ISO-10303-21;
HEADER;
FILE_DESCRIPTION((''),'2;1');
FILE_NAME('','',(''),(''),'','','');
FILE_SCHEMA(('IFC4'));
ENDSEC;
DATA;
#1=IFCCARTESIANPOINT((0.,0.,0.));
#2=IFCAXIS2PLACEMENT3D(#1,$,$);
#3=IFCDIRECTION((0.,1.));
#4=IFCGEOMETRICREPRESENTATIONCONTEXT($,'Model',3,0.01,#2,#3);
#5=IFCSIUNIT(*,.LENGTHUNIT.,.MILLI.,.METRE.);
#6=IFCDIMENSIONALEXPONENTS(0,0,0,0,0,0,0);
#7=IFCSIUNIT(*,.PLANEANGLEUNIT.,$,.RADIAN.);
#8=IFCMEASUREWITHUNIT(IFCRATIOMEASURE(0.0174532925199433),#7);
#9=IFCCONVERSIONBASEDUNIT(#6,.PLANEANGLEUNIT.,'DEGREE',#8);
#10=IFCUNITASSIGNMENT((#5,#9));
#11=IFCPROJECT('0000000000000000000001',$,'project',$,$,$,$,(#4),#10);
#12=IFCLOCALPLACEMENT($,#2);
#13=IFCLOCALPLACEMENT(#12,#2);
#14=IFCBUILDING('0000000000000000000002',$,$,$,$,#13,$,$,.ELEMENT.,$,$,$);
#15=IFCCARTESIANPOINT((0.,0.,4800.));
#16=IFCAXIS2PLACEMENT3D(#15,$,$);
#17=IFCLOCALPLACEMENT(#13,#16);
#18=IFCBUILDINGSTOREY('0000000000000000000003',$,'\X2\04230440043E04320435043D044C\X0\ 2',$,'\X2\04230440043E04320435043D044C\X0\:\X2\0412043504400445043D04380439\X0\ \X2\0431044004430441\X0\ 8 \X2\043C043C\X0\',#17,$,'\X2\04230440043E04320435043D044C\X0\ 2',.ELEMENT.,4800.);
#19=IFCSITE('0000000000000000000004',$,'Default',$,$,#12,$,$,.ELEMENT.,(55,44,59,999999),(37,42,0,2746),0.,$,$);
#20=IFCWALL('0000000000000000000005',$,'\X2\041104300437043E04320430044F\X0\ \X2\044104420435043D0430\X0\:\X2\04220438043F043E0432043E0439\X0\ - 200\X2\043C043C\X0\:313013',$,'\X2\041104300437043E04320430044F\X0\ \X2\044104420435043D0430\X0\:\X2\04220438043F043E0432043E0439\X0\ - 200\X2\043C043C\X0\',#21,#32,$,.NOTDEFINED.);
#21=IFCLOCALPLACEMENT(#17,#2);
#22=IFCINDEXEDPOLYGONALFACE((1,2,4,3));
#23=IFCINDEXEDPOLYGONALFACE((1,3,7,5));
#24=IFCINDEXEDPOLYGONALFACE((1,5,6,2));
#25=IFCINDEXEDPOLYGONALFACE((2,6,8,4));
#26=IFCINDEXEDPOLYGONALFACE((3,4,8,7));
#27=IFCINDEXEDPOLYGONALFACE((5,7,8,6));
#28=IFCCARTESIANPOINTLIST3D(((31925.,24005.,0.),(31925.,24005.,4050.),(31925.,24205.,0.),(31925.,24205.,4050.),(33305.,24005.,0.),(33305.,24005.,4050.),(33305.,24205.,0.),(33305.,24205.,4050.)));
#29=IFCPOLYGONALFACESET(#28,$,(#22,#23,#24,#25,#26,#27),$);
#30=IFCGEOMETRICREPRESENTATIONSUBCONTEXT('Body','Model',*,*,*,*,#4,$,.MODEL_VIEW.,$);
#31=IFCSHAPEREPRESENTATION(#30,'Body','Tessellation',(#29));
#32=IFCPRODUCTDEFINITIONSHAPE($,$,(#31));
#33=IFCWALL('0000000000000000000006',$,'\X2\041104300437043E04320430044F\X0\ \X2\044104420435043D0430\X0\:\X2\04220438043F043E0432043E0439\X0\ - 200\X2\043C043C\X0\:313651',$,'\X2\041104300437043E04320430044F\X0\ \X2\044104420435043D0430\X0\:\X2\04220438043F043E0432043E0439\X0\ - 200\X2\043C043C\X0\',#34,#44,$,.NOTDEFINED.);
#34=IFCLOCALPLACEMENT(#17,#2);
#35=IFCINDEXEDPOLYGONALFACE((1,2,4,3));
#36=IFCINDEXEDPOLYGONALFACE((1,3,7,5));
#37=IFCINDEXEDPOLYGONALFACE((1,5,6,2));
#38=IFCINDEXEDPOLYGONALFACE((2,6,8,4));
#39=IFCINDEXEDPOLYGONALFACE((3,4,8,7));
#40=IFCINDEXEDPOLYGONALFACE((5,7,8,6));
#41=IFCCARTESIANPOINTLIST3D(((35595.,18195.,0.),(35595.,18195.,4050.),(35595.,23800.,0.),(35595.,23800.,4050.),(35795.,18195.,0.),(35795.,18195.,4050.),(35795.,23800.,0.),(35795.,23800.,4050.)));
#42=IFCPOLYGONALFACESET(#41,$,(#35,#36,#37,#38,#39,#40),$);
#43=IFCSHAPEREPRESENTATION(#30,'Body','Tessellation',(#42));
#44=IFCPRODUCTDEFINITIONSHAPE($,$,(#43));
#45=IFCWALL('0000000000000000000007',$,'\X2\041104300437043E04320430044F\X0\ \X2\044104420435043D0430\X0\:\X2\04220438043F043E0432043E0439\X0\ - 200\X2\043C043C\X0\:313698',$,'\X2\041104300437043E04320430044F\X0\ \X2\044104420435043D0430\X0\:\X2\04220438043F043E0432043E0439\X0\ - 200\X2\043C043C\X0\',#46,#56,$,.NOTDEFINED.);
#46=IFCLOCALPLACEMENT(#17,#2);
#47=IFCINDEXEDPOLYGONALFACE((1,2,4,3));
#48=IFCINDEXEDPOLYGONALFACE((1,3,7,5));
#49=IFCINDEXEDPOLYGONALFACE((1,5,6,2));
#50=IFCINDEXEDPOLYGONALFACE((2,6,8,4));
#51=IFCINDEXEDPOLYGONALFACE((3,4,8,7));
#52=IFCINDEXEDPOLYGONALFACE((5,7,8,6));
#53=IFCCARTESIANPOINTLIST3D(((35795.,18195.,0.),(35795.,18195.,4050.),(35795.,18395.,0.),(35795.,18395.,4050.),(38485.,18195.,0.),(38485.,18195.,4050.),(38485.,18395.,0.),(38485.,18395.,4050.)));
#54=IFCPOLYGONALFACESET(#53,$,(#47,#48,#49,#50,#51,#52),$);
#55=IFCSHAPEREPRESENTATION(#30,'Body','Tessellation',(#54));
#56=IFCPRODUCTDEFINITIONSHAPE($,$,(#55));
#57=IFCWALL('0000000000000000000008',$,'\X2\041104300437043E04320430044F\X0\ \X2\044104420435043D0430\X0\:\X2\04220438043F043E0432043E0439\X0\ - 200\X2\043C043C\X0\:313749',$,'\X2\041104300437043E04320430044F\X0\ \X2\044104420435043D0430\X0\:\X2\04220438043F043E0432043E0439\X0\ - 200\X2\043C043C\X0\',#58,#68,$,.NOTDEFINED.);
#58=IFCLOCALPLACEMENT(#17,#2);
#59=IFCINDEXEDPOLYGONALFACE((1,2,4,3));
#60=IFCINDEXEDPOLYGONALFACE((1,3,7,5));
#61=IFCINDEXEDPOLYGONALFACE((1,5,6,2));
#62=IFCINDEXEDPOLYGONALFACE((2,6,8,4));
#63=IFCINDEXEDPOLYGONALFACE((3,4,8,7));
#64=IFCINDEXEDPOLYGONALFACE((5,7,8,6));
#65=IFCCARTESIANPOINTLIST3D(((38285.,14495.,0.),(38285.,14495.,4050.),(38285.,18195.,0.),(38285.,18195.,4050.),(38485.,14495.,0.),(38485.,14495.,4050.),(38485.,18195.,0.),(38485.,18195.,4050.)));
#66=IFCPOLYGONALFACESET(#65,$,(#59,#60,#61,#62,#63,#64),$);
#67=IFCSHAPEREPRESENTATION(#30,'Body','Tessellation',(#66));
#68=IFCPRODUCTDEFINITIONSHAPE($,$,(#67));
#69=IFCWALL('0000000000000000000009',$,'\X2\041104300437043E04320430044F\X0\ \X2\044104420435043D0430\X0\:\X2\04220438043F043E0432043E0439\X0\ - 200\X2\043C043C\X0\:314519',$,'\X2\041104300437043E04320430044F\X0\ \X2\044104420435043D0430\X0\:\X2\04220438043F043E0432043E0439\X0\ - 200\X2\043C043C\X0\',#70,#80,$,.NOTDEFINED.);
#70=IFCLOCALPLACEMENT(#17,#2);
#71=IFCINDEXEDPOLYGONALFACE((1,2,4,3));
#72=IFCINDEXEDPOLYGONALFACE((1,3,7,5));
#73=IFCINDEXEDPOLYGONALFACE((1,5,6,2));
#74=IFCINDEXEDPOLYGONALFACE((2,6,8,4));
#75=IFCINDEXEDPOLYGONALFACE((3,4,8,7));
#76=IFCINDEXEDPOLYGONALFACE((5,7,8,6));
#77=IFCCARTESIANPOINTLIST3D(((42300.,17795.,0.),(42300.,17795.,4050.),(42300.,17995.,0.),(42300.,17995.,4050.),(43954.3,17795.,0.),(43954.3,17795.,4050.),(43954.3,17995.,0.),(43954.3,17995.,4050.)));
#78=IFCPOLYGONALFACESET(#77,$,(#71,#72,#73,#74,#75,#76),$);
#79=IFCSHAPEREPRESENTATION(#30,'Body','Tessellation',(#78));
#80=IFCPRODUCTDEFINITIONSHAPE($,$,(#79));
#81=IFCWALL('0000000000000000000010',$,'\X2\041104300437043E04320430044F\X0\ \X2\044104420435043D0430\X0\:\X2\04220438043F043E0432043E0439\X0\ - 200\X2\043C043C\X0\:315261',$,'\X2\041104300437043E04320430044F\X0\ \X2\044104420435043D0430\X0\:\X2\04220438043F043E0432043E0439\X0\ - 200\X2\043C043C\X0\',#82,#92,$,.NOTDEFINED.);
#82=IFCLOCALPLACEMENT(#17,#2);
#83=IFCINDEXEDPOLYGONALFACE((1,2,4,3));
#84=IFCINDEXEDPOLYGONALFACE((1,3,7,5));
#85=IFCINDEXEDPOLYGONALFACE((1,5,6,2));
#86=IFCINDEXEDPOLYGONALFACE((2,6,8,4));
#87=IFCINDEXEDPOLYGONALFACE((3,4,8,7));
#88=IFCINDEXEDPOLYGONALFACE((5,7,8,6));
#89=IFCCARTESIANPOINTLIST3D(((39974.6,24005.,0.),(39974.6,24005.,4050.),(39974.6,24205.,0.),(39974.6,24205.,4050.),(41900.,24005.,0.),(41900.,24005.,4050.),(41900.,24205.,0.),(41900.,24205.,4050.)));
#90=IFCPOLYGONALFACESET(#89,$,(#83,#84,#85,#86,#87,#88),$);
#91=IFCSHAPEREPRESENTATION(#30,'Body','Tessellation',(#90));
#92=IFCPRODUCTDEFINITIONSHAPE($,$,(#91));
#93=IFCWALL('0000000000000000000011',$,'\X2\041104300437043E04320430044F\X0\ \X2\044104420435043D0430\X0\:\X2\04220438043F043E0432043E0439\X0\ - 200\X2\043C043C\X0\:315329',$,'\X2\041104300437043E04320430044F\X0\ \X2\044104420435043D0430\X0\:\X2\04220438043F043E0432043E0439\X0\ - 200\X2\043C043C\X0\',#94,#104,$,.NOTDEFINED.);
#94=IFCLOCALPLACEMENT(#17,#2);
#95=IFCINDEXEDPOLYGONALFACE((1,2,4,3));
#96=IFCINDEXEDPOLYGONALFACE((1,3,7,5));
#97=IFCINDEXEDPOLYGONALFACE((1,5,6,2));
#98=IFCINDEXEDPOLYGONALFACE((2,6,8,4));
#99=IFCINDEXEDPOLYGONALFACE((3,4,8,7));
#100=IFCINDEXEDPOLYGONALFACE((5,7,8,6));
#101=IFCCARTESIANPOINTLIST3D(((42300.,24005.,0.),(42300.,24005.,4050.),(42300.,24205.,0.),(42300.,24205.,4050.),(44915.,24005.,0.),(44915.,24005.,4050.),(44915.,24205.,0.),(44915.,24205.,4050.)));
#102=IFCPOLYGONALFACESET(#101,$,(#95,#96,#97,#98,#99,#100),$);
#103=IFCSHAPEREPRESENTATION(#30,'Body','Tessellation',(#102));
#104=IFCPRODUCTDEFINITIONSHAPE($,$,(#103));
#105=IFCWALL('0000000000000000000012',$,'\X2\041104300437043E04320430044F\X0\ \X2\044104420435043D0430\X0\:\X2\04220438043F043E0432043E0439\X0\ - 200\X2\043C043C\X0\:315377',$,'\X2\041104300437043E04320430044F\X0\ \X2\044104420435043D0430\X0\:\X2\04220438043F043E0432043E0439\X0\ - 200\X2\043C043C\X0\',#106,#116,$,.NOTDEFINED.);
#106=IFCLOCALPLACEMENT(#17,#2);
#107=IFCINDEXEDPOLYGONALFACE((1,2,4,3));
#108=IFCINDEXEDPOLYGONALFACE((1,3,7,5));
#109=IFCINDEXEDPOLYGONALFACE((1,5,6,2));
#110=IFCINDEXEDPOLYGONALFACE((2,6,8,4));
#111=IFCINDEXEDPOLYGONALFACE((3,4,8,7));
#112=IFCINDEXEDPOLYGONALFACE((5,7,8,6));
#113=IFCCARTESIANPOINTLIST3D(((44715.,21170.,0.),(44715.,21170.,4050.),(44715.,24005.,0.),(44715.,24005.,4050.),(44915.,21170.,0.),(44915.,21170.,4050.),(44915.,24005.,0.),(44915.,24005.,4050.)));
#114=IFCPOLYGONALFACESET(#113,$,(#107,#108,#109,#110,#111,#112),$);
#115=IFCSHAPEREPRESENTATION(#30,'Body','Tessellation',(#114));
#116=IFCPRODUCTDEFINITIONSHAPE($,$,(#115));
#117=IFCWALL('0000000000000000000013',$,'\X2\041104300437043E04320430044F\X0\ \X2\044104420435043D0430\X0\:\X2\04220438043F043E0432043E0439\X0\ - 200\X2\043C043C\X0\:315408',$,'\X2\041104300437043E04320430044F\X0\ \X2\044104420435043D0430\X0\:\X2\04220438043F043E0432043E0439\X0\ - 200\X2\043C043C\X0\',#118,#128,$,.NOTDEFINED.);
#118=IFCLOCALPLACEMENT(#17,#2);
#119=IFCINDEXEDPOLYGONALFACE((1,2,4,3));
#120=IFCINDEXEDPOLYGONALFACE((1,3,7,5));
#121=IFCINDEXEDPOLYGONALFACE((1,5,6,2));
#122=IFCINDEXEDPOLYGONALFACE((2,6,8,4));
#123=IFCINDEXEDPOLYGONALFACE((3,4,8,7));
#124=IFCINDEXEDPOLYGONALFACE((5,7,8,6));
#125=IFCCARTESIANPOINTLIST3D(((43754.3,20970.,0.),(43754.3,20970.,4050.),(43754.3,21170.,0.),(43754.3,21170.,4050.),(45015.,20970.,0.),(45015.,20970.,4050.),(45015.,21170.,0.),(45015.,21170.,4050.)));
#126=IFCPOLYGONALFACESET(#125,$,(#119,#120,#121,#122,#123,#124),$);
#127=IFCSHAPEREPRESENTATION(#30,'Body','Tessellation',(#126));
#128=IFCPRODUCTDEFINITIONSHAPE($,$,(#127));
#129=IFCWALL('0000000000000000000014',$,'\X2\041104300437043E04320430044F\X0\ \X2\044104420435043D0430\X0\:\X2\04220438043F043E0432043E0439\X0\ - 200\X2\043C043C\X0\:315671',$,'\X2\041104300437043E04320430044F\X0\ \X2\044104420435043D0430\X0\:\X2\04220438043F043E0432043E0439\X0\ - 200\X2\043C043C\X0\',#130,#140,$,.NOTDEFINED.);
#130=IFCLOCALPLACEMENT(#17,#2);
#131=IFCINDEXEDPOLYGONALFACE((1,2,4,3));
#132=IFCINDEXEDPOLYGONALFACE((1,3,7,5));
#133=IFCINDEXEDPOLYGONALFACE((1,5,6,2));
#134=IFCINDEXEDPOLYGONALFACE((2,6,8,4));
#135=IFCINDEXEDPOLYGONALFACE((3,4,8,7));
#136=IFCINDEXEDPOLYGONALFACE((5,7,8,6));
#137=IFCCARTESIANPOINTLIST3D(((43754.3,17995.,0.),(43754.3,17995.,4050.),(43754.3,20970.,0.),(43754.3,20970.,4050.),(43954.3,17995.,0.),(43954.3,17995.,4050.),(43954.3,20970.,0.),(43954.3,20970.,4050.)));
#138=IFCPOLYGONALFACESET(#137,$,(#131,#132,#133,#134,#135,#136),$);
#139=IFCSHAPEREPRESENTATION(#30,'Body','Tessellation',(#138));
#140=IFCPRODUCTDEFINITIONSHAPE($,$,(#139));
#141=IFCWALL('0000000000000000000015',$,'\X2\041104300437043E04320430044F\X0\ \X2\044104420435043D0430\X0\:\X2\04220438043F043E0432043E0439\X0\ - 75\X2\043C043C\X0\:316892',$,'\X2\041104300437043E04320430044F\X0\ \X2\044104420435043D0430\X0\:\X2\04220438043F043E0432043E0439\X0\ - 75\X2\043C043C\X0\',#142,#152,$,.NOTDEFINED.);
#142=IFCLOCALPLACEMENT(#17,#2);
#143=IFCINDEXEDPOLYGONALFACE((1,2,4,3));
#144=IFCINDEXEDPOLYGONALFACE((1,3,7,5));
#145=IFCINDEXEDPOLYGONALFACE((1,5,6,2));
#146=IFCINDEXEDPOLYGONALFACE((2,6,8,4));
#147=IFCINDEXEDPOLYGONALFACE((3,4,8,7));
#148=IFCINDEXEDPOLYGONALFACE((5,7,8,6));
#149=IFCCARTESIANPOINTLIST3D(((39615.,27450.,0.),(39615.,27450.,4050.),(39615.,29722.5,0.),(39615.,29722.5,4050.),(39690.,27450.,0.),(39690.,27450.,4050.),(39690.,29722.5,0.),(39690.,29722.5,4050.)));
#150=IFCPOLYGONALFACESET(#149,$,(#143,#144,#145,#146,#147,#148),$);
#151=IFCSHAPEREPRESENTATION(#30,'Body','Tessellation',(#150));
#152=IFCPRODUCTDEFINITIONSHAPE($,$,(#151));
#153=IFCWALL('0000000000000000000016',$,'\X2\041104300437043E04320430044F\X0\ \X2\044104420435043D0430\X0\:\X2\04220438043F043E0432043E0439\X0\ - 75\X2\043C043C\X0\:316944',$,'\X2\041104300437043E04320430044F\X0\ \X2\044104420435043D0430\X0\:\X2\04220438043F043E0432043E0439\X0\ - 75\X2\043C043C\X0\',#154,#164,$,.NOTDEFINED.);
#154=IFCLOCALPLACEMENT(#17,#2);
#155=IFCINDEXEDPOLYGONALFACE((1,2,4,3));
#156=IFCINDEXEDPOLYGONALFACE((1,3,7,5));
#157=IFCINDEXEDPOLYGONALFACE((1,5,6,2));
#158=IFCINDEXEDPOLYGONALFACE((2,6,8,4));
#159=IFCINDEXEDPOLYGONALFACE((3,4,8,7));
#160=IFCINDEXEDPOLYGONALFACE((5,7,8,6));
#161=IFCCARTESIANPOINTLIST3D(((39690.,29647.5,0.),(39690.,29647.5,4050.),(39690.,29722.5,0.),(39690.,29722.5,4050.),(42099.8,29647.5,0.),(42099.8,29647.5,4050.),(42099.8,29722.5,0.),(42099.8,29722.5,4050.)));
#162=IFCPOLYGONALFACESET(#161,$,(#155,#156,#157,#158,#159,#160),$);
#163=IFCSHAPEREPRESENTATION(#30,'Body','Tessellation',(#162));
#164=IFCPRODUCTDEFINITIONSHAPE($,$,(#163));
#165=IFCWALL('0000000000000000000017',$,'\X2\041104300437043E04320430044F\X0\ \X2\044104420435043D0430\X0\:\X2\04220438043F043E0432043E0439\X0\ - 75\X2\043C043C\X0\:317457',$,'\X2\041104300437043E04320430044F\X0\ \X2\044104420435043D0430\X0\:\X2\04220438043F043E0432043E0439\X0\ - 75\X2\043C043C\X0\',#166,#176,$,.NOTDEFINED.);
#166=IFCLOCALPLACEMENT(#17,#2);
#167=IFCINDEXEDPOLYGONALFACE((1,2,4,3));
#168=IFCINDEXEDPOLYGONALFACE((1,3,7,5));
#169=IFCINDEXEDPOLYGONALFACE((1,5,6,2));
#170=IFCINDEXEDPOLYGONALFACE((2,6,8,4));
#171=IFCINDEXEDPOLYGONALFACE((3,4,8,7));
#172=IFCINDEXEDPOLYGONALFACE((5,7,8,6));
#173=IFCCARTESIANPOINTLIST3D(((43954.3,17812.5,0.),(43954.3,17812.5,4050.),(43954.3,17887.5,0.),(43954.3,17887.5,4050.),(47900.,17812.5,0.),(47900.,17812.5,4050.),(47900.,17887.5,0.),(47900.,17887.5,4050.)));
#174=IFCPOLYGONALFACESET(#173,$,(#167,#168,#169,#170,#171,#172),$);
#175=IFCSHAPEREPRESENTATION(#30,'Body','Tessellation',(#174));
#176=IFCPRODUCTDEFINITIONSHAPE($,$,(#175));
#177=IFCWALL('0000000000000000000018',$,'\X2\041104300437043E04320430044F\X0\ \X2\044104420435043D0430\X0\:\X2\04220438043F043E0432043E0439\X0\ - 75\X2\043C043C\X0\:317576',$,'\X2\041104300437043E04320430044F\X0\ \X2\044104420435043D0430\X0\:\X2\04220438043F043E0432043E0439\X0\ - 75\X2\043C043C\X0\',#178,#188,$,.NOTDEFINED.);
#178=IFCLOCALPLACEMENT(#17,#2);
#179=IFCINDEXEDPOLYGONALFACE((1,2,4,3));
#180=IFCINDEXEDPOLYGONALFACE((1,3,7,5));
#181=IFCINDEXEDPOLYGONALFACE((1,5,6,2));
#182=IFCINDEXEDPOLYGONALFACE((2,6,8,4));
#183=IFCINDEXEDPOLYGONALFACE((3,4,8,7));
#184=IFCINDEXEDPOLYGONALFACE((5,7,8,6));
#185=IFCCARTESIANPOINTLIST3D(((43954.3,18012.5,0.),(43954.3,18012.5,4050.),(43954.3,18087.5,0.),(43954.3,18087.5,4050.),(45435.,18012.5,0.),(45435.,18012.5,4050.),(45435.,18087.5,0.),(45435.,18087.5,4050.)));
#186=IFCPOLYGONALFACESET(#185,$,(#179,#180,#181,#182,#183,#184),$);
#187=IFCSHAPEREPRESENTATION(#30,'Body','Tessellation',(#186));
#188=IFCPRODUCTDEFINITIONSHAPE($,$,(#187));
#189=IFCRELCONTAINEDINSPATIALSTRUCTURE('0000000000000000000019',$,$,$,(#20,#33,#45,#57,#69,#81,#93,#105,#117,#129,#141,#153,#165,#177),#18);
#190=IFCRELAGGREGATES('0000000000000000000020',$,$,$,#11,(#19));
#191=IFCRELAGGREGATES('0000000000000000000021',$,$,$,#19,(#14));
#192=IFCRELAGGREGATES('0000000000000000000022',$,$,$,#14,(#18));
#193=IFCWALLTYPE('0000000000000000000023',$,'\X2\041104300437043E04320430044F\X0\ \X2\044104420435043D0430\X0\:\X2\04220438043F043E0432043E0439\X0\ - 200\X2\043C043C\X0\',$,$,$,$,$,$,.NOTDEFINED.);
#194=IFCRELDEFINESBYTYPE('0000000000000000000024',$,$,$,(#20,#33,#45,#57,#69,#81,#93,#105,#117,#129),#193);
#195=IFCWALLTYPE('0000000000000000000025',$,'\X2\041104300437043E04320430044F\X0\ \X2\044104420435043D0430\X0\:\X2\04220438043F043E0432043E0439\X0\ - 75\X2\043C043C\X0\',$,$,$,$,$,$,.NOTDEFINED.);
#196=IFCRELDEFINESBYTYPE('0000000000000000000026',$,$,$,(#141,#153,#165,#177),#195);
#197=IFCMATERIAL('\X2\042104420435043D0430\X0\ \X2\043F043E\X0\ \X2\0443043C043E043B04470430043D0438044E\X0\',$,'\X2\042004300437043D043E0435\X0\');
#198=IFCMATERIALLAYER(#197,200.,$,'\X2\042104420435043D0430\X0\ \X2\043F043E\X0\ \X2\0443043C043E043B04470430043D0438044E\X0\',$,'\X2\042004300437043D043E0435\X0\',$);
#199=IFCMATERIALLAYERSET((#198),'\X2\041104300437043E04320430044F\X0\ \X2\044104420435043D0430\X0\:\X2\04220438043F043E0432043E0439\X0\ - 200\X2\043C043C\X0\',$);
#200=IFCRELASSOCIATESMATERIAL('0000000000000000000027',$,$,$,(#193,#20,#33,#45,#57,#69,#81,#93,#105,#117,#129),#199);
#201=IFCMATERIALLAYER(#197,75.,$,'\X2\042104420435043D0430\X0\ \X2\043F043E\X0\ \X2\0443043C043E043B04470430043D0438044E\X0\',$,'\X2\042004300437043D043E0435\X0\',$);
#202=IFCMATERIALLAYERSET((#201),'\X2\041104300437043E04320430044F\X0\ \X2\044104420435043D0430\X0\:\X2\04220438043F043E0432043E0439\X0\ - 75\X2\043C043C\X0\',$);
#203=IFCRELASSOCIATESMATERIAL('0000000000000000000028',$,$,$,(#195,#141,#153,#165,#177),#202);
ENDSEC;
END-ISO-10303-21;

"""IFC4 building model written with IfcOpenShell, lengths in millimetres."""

from ifc_helpers import new_model, entity, si_unit, converted_unit, direction, frame, frame_2d, origin, place, context, subcontext, project, spatial, rectangle, extrude, material, layer, layer_set, layer_usage, type_object, element, save


model = new_model("IFC4")

# Units and contexts
model_context = context("Model", 3, precision=0.01, world=origin(), true_north=direction((0.0, 1.0)))
body_context = subcontext(model_context, "Body", "Model", "MODEL_VIEW")
ifc_project = project(units=[si_unit("LENGTHUNIT", "METRE", prefix="MILLI"), converted_unit("PLANEANGLEUNIT", "DEGREE", entity("IfcRatioMeasure", 0.0174532925199433), si_unit("PLANEANGLEUNIT", "RADIAN"), dimensions=[0, 0, 0, 0, 0, 0, 0])], contexts=[model_context])

# Site, building, storey
site_placement = place(None, origin())
site = spatial("IfcSite", under=ifc_project, at=site_placement, Name="Default", CompositionType="ELEMENT", RefLatitude=(55, 44, 59, 999999), RefLongitude=(37, 42, 0, 2746), RefElevation=0.0)
building_placement = place(site_placement, origin())
building = spatial("IfcBuilding", under=site, at=building_placement, CompositionType="ELEMENT")
storey_placement = place(building_placement, frame((0.0, 0.0, 4800.0)))
storey = spatial("IfcBuildingStorey", under=building, at=storey_placement, Name="Уровень 2", ObjectType="Уровень:Верхний брус 8 мм", LongName="Уровень 2", CompositionType="ELEMENT", Elevation=4800.0)

# Walls
ifc_material_1 = material(Name="Стена по умолчанию", Category="Разное")
ifc_layer_1 = layer(ifc_material_1, 200.0, Name="Стена по умолчанию", Category="Разное")
ifc_layer_set_1 = layer_set([ifc_layer_1], Name="Базовая стена:Типовой - 200мм")
ifc_layer_usage_1 = layer_usage(ifc_layer_set_1, "AXIS2", "NEGATIVE", 100.0)
wall_type_1 = type_object("IfcWallType", Name="Базовая стена:Типовой - 200мм", PredefinedType="NOTDEFINED", material=ifc_layer_set_1)
wall_1_placement = place(storey_placement, frame((33305.0, 24105.0, 0.0), z_axis=(0.0, 0.0, 1.0), x_axis=(-1.0, 0.0, 0.0)))
element("IfcWall", 1, at=wall_1_placement, inside=storey, type_object=wall_type_1, material=ifc_layer_usage_1, Name="Базовая стена:Типовой - 200мм:313013", ObjectType="Базовая стена:Типовой - 200мм", PredefinedType="NOTDEFINED", context=body_context, shape_type="SweptSolid", body=[
    extrude(rectangle(XDim=1380.0, YDim=200.0, at=frame_2d((690.0, 0.0), x_axis=(-1.0, 0.0))), origin(), (0.0, 0.0, 1.0), 4050.0),
])
ifc_layer_usage_2 = layer_usage(ifc_layer_set_1, "AXIS2", "NEGATIVE", 100.0)
wall_2_placement = place(storey_placement, frame((35695.0, 23800.0, 0.0), z_axis=(0.0, 0.0, 1.0), x_axis=(0.0, -1.0, 0.0)))
element("IfcWall", 2, at=wall_2_placement, inside=storey, type_object=wall_type_1, material=ifc_layer_usage_2, Name="Базовая стена:Типовой - 200мм:313651", ObjectType="Базовая стена:Типовой - 200мм", PredefinedType="NOTDEFINED", context=body_context, shape_type="SweptSolid", body=[
    extrude(rectangle(XDim=5605.0, YDim=200.0, at=frame_2d((2802.5, 0.0), x_axis=(-1.0, 0.0))), origin(), (0.0, 0.0, 1.0), 4050.0),
])
ifc_layer_usage_3 = layer_usage(ifc_layer_set_1, "AXIS2", "NEGATIVE", 100.0)
wall_3_placement = place(storey_placement, frame((35795.0, 18295.0, 0.0)))
element("IfcWall", 3, at=wall_3_placement, inside=storey, type_object=wall_type_1, material=ifc_layer_usage_3, Name="Базовая стена:Типовой - 200мм:313698", ObjectType="Базовая стена:Типовой - 200мм", PredefinedType="NOTDEFINED", context=body_context, shape_type="SweptSolid", body=[
    extrude(rectangle(XDim=2690.0, YDim=200.0, at=frame_2d((1345.0, 0.0), x_axis=(-1.0, 0.0))), origin(), (0.0, 0.0, 1.0), 4050.0),
])
ifc_layer_usage_4 = layer_usage(ifc_layer_set_1, "AXIS2", "NEGATIVE", 100.0)
wall_4_placement = place(storey_placement, frame((38385.0, 18195.0, 0.0), z_axis=(0.0, 0.0, 1.0), x_axis=(0.0, -1.0, 0.0)))
element("IfcWall", 4, at=wall_4_placement, inside=storey, type_object=wall_type_1, material=ifc_layer_usage_4, Name="Базовая стена:Типовой - 200мм:313749", ObjectType="Базовая стена:Типовой - 200мм", PredefinedType="NOTDEFINED", context=body_context, shape_type="SweptSolid", body=[
    extrude(rectangle(XDim=3700.0, YDim=200.0, at=frame_2d((1850.0, 0.0), x_axis=(-1.0, 0.0))), origin(), (0.0, 0.0, 1.0), 4050.0),
])
ifc_layer_usage_5 = layer_usage(ifc_layer_set_1, "AXIS2", "NEGATIVE", 100.0)
wall_5_placement = place(storey_placement, frame((42300.0, 17895.0, 0.0)))
element("IfcWall", 5, at=wall_5_placement, inside=storey, type_object=wall_type_1, material=ifc_layer_usage_5, Name="Базовая стена:Типовой - 200мм:314519", ObjectType="Базовая стена:Типовой - 200мм", PredefinedType="NOTDEFINED", context=body_context, shape_type="SweptSolid", body=[
    extrude(rectangle(XDim=1654.3, YDim=200.0, at=frame_2d((827.2, 0.0), x_axis=(-1.0, 0.0))), origin(), (0.0, 0.0, 1.0), 4050.0),
])

# Walls
ifc_layer_usage_6 = layer_usage(ifc_layer_set_1, "AXIS2", "NEGATIVE", 100.0)
wall_6_placement = place(storey_placement, frame((39974.6, 24105.0, 0.0)))
element("IfcWall", 6, at=wall_6_placement, inside=storey, type_object=wall_type_1, material=ifc_layer_usage_6, Name="Базовая стена:Типовой - 200мм:315261", ObjectType="Базовая стена:Типовой - 200мм", PredefinedType="NOTDEFINED", context=body_context, shape_type="SweptSolid", body=[
    extrude(rectangle(XDim=1925.4, YDim=200.0, at=frame_2d((962.7, 0.0), x_axis=(-1.0, 0.0))), origin(), (0.0, 0.0, 1.0), 4050.0),
])
ifc_layer_usage_7 = layer_usage(ifc_layer_set_1, "AXIS2", "NEGATIVE", 100.0)
wall_7_placement = place(storey_placement, frame((42300.0, 24105.0, 0.0)))
element("IfcWall", 7, at=wall_7_placement, inside=storey, type_object=wall_type_1, material=ifc_layer_usage_7, Name="Базовая стена:Типовой - 200мм:315329", ObjectType="Базовая стена:Типовой - 200мм", PredefinedType="NOTDEFINED", context=body_context, shape_type="SweptSolid", body=[
    extrude(rectangle(XDim=2615.0, YDim=200.0, at=frame_2d((1307.5, 0.0), x_axis=(-1.0, 0.0))), origin(), (0.0, 0.0, 1.0), 4050.0),
])
ifc_layer_usage_8 = layer_usage(ifc_layer_set_1, "AXIS2", "NEGATIVE", 100.0)
wall_8_placement = place(storey_placement, frame((44815.0, 24005.0, 0.0), z_axis=(0.0, 0.0, 1.0), x_axis=(0.0, -1.0, 0.0)))
element("IfcWall", 8, at=wall_8_placement, inside=storey, type_object=wall_type_1, material=ifc_layer_usage_8, Name="Базовая стена:Типовой - 200мм:315377", ObjectType="Базовая стена:Типовой - 200мм", PredefinedType="NOTDEFINED", context=body_context, shape_type="SweptSolid", body=[
    extrude(rectangle(XDim=2835.0, YDim=200.0, at=frame_2d((1417.5, 0.0), x_axis=(-1.0, 0.0))), origin(), (0.0, 0.0, 1.0), 4050.0),
])
ifc_layer_usage_9 = layer_usage(ifc_layer_set_1, "AXIS2", "NEGATIVE", 100.0)
wall_9_placement = place(storey_placement, frame((43754.3, 21070.0, 0.0)))
element("IfcWall", 9, at=wall_9_placement, inside=storey, type_object=wall_type_1, material=ifc_layer_usage_9, Name="Базовая стена:Типовой - 200мм:315408", ObjectType="Базовая стена:Типовой - 200мм", PredefinedType="NOTDEFINED", context=body_context, shape_type="SweptSolid", body=[
    extrude(rectangle(XDim=1260.7, YDim=200.0, at=frame_2d((630.3, 0.0), x_axis=(-1.0, 0.0))), origin(), (0.0, 0.0, 1.0), 4050.0),
])
ifc_layer_usage_10 = layer_usage(ifc_layer_set_1, "AXIS2", "NEGATIVE", 100.0)
wall_10_placement = place(storey_placement, frame((43854.3, 20970.0, 0.0), z_axis=(0.0, 0.0, 1.0), x_axis=(0.0, -1.0, 0.0)))
element("IfcWall", 10, at=wall_10_placement, inside=storey, type_object=wall_type_1, material=ifc_layer_usage_10, Name="Базовая стена:Типовой - 200мм:315671", ObjectType="Базовая стена:Типовой - 200мм", PredefinedType="NOTDEFINED", context=body_context, shape_type="SweptSolid", body=[
    extrude(rectangle(XDim=2975.0, YDim=200.0, at=frame_2d((1487.5, 0.0), x_axis=(-1.0, 0.0))), origin(), (0.0, 0.0, 1.0), 4050.0),
])
ifc_layer_2 = layer(ifc_material_1, 75.0, Name="Стена по умолчанию", Category="Разное")
ifc_layer_set_2 = layer_set([ifc_layer_2], Name="Базовая стена:Типовой - 75мм")
ifc_layer_usage_11 = layer_usage(ifc_layer_set_2, "AXIS2", "NEGATIVE", 37.5)
wall_type_2 = type_object("IfcWallType", Name="Базовая стена:Типовой - 75мм", PredefinedType="NOTDEFINED", material=ifc_layer_set_2)
wall_11_placement = place(storey_placement, frame((39652.5, 27450.0, 0.0), z_axis=(0.0, 0.0, 1.0), x_axis=(0.0, 1.0, 0.0)))
element("IfcWall", 11, at=wall_11_placement, inside=storey, type_object=wall_type_2, material=ifc_layer_usage_11, Name="Базовая стена:Типовой - 75мм:316892", ObjectType="Базовая стена:Типовой - 75мм", PredefinedType="NOTDEFINED", context=body_context, shape_type="SweptSolid", body=[
    extrude(rectangle(XDim=2272.5, YDim=75.0, at=frame_2d((1136.2, 0.0), x_axis=(-1.0, 0.0))), origin(), (0.0, 0.0, 1.0), 4050.0),
])
ifc_layer_usage_12 = layer_usage(ifc_layer_set_2, "AXIS2", "NEGATIVE", 37.5)
wall_12_placement = place(storey_placement, frame((39690.0, 29685.0, 0.0)))
element("IfcWall", 12, at=wall_12_placement, inside=storey, type_object=wall_type_2, material=ifc_layer_usage_12, Name="Базовая стена:Типовой - 75мм:316944", ObjectType="Базовая стена:Типовой - 75мм", PredefinedType="NOTDEFINED", context=body_context, shape_type="SweptSolid", body=[
    extrude(rectangle(XDim=2409.8, YDim=75.0, at=frame_2d((1204.9, 0.0), x_axis=(-1.0, 0.0))), origin(), (0.0, 0.0, 1.0), 4050.0),
])
ifc_layer_usage_13 = layer_usage(ifc_layer_set_2, "AXIS2", "NEGATIVE", 37.5)
wall_13_placement = place(storey_placement, frame((43954.3, 17850.0, 0.0)))
element("IfcWall", 13, at=wall_13_placement, inside=storey, type_object=wall_type_2, material=ifc_layer_usage_13, Name="Базовая стена:Типовой - 75мм:317457", ObjectType="Базовая стена:Типовой - 75мм", PredefinedType="NOTDEFINED", context=body_context, shape_type="SweptSolid", body=[
    extrude(rectangle(XDim=3945.7, YDim=75.0, at=frame_2d((1972.8, 0.0), x_axis=(-1.0, 0.0))), origin(), (0.0, 0.0, 1.0), 4050.0),
])
ifc_layer_usage_14 = layer_usage(ifc_layer_set_2, "AXIS2", "NEGATIVE", 37.5)
wall_14_placement = place(storey_placement, frame((43954.3, 18050.0, 0.0)))
element("IfcWall", 14, at=wall_14_placement, inside=storey, type_object=wall_type_2, material=ifc_layer_usage_14, Name="Базовая стена:Типовой - 75мм:317576", ObjectType="Базовая стена:Типовой - 75мм", PredefinedType="NOTDEFINED", context=body_context, shape_type="SweptSolid", body=[
    extrude(rectangle(XDim=1480.7, YDim=75.0, at=frame_2d((740.3, 0.0), x_axis=(-1.0, 0.0))), origin(), (0.0, 0.0, 1.0), 4050.0),
])

save(model, "model.ifc")
